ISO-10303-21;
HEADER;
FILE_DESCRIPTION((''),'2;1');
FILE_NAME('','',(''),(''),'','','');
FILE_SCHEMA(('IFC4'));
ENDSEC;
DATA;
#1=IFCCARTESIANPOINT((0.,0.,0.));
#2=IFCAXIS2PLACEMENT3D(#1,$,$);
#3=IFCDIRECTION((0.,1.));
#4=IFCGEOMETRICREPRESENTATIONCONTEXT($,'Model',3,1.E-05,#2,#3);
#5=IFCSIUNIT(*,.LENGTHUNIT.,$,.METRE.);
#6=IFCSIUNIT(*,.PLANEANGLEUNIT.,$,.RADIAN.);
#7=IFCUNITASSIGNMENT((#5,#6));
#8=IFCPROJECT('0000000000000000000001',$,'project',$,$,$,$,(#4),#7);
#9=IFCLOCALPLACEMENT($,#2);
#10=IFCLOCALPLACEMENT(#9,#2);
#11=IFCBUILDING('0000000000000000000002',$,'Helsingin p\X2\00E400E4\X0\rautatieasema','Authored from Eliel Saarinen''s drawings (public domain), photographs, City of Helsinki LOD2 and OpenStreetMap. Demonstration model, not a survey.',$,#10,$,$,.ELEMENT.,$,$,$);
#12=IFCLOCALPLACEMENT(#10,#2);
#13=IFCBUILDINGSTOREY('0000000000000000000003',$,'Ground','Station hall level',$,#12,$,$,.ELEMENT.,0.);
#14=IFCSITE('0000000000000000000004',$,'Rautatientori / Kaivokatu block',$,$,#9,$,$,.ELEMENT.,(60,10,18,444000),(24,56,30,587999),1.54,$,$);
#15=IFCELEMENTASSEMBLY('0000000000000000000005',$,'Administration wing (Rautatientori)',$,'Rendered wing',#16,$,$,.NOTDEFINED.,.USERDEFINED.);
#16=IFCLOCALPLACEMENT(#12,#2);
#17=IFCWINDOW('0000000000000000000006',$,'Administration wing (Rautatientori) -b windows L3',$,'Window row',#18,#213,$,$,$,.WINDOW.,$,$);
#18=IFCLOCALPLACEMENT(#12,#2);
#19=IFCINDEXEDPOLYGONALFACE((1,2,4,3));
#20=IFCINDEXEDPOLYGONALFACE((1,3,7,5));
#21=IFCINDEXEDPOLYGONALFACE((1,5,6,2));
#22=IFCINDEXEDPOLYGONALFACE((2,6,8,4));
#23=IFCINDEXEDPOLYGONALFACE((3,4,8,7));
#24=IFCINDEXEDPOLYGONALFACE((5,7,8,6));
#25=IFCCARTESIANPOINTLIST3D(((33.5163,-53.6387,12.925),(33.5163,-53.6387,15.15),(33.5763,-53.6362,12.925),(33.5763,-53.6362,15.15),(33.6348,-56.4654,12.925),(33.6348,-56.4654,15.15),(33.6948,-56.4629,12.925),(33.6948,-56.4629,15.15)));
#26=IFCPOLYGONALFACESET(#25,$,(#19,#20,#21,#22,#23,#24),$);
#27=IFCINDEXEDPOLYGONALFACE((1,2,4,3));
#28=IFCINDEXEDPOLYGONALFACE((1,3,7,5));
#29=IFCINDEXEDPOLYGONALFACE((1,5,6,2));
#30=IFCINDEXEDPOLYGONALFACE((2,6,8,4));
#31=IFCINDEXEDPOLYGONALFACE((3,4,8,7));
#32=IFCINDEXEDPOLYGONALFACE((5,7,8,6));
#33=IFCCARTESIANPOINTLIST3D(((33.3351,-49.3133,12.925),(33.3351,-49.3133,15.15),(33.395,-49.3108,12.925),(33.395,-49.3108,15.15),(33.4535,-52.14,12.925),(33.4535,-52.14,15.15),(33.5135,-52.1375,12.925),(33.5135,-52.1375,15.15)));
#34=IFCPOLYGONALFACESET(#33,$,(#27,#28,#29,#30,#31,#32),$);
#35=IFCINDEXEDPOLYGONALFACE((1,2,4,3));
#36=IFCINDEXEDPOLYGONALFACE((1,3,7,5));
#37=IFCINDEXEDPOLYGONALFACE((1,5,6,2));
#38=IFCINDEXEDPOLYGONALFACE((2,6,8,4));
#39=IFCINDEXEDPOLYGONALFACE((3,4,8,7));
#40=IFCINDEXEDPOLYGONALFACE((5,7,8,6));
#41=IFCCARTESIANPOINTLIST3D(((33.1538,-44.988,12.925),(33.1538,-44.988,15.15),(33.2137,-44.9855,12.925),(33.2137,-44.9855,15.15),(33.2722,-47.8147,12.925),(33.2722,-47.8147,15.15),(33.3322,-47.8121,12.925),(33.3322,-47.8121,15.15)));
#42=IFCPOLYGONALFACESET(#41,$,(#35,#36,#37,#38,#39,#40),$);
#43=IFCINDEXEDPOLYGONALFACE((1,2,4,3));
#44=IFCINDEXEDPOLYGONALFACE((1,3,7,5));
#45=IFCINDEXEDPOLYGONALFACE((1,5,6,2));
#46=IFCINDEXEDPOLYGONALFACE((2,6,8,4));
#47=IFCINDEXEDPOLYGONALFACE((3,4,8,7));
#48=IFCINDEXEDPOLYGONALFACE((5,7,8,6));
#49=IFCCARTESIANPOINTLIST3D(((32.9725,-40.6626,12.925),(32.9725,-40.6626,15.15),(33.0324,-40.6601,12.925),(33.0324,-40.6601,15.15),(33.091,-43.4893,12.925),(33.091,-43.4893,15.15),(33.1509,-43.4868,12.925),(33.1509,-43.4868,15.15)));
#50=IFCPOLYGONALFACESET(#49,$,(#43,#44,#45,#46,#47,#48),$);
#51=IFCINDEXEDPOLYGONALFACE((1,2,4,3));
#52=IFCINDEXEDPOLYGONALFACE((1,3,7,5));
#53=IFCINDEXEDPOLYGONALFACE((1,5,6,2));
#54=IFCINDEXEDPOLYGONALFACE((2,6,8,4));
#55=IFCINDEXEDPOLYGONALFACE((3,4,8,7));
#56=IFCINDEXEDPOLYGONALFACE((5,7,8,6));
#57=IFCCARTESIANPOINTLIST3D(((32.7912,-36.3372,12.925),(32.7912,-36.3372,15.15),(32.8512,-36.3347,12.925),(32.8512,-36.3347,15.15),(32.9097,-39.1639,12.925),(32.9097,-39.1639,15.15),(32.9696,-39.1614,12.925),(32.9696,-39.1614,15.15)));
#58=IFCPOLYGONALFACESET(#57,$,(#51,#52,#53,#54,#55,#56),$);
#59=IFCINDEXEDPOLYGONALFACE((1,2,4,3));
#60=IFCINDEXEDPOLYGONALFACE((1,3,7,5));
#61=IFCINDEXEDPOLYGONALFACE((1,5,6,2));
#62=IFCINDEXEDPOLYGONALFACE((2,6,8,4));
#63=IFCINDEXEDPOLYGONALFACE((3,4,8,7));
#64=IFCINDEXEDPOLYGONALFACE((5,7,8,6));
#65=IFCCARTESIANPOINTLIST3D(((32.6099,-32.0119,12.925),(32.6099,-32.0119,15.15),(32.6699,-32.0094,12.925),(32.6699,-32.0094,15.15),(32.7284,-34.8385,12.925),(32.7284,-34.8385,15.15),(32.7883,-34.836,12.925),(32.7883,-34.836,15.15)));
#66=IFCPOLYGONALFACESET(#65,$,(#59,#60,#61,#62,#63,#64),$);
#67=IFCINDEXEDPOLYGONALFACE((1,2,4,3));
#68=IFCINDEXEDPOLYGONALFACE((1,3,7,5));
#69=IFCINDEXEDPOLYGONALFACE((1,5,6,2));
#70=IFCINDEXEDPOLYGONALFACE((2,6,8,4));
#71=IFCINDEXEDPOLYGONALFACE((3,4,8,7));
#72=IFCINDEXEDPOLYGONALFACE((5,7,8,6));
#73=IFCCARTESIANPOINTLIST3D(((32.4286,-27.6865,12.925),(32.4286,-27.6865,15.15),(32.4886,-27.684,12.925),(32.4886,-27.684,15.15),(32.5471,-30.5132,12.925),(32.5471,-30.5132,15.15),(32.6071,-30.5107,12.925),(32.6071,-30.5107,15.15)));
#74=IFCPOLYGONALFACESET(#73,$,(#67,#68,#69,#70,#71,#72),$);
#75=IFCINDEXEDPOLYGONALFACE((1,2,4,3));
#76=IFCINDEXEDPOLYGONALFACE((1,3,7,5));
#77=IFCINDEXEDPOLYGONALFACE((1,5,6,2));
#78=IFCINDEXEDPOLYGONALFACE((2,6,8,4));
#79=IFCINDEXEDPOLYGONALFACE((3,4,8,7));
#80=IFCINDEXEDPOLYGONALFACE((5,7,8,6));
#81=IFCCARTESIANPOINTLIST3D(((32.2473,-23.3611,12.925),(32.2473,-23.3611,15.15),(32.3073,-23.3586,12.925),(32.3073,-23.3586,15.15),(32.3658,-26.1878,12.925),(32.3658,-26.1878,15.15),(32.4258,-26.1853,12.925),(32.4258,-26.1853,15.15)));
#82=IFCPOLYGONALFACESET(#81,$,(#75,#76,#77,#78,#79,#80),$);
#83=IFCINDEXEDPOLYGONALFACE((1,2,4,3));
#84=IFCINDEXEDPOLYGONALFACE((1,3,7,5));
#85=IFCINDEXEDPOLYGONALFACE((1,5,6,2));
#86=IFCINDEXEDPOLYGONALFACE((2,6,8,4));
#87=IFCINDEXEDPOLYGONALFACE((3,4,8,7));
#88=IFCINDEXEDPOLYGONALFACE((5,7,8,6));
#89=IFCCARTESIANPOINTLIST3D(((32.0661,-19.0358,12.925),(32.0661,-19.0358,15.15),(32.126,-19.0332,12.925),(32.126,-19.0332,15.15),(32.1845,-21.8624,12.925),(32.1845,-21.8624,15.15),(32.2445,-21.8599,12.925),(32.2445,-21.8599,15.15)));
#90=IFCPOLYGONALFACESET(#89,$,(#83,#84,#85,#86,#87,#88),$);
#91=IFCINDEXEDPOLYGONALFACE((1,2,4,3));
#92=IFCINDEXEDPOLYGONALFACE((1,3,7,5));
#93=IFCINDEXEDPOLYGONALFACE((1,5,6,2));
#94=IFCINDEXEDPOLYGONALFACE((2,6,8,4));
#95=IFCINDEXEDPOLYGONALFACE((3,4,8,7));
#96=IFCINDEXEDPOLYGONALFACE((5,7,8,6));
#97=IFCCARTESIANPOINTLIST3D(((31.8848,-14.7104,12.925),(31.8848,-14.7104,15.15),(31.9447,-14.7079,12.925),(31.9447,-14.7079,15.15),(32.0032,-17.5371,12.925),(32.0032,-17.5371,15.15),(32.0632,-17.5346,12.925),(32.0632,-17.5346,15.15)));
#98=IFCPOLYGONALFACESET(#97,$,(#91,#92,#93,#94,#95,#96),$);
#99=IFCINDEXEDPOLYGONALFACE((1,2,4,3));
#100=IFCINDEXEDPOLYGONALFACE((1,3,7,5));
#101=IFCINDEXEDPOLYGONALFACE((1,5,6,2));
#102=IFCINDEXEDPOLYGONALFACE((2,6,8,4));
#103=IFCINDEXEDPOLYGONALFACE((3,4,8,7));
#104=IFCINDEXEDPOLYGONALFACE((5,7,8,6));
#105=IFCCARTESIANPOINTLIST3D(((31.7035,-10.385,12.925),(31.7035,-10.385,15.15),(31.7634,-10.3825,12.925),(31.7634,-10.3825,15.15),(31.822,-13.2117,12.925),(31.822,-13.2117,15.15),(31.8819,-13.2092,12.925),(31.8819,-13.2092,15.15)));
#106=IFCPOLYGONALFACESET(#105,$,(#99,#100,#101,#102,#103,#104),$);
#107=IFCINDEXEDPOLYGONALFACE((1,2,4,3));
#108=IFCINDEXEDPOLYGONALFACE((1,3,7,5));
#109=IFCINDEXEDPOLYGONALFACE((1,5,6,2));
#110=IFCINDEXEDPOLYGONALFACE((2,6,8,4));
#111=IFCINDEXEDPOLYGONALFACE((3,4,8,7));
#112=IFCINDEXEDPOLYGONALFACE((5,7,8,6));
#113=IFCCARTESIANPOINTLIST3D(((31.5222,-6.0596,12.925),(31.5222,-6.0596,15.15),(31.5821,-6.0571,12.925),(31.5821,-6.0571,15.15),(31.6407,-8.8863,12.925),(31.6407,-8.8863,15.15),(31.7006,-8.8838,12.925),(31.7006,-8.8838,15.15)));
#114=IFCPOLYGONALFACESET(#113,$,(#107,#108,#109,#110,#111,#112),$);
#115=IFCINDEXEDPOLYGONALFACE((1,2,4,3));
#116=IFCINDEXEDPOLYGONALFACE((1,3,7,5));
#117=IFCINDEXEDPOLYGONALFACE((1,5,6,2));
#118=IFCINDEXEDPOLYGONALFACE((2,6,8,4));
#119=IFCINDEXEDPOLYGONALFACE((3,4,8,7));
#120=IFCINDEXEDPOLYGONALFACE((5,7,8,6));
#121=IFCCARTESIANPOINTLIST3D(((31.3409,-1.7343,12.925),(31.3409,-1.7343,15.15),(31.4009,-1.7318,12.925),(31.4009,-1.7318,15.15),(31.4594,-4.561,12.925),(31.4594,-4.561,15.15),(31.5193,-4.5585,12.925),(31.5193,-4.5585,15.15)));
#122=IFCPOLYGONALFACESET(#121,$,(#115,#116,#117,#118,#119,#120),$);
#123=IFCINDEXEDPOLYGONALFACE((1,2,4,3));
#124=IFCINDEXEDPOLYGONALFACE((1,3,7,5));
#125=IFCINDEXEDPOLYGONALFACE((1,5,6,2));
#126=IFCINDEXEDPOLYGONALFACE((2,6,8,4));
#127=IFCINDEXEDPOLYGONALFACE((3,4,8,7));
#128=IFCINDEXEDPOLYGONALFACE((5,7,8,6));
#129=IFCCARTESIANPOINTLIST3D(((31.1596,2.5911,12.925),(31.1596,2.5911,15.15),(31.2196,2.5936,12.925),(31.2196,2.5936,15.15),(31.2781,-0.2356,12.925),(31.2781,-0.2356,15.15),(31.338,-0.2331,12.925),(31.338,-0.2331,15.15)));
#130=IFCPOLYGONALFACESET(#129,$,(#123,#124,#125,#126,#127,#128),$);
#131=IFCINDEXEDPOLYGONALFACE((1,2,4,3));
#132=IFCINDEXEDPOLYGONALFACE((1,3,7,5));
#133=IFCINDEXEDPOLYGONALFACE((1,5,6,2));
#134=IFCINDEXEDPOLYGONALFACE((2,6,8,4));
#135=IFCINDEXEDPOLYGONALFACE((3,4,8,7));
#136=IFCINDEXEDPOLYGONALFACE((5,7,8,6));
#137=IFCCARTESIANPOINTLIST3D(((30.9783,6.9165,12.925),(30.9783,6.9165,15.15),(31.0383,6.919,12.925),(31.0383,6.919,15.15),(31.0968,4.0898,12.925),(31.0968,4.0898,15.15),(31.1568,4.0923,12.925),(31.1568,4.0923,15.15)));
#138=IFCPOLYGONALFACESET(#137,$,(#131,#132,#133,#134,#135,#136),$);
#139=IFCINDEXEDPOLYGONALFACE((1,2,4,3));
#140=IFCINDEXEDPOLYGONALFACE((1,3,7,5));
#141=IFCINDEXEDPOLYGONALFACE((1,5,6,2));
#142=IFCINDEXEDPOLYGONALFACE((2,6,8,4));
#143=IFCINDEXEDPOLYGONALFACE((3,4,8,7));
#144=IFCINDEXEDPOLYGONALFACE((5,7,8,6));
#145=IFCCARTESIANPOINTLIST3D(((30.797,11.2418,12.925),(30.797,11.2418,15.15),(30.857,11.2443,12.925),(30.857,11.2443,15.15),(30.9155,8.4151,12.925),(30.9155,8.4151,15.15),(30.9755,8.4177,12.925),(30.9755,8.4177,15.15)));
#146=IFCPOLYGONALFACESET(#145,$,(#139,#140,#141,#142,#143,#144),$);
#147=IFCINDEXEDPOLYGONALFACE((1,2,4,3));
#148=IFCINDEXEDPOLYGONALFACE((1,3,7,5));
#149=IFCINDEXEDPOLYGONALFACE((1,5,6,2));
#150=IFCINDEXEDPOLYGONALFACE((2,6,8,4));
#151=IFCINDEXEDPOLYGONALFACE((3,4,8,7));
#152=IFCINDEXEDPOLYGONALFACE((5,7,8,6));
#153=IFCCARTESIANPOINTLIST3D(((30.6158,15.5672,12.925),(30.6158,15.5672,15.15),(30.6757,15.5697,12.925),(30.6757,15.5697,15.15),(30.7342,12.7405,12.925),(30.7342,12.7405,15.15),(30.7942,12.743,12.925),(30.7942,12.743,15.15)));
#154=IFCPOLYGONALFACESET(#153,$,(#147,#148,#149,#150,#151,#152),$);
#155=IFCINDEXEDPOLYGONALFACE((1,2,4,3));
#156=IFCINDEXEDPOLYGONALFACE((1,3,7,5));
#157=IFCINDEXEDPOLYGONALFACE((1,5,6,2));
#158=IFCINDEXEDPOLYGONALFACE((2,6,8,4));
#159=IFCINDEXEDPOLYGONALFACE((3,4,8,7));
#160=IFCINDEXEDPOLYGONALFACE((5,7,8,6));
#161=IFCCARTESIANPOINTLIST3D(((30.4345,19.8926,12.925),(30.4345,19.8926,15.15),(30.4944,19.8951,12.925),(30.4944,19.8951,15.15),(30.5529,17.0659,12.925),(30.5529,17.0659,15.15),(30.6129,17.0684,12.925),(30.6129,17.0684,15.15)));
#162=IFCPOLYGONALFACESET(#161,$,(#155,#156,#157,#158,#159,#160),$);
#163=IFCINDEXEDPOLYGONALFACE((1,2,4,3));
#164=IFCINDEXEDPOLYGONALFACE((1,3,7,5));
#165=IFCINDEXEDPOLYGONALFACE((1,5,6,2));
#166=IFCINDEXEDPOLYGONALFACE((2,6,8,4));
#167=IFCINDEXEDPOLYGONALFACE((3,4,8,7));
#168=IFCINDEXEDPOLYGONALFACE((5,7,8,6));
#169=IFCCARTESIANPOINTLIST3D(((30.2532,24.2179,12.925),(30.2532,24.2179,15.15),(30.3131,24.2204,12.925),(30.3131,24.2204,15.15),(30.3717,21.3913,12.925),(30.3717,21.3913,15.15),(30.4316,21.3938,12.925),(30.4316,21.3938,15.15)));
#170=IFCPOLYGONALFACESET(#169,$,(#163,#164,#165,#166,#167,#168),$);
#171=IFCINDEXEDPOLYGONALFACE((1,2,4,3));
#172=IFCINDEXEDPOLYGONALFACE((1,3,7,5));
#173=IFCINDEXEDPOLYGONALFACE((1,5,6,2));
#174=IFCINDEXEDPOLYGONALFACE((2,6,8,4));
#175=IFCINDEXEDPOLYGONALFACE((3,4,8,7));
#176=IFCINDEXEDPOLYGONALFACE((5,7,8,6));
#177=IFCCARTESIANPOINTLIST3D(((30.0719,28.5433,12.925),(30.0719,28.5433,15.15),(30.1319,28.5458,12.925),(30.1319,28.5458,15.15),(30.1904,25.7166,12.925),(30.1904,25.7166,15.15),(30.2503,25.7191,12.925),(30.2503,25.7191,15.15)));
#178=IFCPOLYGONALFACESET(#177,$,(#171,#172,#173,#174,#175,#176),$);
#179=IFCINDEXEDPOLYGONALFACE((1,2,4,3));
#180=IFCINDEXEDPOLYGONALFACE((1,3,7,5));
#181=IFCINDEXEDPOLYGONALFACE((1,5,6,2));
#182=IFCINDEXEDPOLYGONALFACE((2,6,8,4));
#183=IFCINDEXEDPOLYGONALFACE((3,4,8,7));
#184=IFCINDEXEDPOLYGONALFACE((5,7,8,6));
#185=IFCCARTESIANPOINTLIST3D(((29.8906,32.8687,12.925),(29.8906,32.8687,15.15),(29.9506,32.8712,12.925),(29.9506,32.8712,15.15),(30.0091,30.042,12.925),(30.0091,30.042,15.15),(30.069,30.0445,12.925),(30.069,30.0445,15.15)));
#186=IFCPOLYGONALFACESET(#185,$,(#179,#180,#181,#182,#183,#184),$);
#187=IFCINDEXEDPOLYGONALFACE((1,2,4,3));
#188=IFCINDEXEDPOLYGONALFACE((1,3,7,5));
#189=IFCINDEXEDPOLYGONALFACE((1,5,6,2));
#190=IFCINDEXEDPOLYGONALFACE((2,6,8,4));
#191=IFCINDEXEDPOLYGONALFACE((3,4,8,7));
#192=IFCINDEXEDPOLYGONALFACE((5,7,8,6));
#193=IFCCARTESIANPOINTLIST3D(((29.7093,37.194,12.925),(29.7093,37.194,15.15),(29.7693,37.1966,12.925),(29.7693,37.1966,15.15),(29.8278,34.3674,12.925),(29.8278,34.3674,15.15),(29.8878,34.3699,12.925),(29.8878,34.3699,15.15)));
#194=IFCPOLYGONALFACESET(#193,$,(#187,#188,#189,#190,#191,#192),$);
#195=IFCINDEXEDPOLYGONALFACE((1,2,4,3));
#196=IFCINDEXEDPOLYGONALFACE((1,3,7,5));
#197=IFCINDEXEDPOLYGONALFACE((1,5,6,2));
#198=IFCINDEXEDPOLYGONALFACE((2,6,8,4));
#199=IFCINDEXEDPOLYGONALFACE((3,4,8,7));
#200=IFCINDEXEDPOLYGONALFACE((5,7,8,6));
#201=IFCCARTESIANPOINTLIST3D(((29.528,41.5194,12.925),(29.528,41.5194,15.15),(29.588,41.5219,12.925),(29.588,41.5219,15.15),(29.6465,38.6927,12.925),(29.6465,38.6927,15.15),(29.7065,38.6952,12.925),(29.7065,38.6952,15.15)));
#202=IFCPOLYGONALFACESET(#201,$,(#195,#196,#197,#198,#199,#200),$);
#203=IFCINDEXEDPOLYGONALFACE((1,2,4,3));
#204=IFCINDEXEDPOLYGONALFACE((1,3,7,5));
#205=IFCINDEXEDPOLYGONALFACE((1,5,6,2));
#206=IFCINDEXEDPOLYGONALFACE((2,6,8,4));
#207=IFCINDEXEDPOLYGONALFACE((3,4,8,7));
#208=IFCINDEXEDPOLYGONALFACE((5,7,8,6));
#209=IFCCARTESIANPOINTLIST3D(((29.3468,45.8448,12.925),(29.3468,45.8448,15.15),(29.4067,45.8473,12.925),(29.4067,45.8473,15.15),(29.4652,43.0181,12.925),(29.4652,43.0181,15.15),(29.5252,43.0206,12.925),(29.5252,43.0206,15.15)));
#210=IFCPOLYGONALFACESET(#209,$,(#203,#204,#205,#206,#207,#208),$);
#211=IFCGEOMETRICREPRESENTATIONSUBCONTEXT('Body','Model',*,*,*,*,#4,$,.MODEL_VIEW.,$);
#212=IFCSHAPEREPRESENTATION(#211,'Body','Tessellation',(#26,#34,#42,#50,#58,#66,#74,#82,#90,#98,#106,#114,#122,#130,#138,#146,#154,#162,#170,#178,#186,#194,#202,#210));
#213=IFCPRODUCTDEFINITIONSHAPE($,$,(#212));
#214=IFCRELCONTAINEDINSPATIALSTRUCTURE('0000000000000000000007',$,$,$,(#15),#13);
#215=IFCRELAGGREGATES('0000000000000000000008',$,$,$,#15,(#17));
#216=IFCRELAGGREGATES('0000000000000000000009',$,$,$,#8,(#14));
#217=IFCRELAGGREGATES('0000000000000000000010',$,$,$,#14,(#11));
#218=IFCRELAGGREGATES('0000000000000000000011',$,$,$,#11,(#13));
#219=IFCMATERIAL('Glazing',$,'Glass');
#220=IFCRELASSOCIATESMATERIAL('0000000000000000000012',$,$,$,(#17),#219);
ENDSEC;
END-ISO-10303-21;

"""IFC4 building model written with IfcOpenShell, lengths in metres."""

from ifc_helpers import new_model, si_unit, direction, frame, frame_2d, origin, place, context, subcontext, project, spatial, rectangle, extrude, material, element, aggregate, save


model = new_model("IFC4")

# Units and contexts
model_context = context("Model", 3, precision=1e-05, world=origin(), true_north=direction((0.0, 1.0)))
body_context = subcontext(model_context, "Body", "Model", "MODEL_VIEW")
ifc_project = project(units=[si_unit("LENGTHUNIT", "METRE"), si_unit("PLANEANGLEUNIT", "RADIAN")], contexts=[model_context])

# Site, building, storey
site_placement = place(None, origin())
site = spatial("IfcSite", under=ifc_project, at=site_placement, Name="Rautatientori / Kaivokatu block", CompositionType="ELEMENT", RefLatitude=(60, 10, 18, 444000), RefLongitude=(24, 56, 30, 587999), RefElevation=1.54)
building_placement = place(site_placement, origin())
building = spatial("IfcBuilding", under=site, at=building_placement, Name="Helsingin päärautatieasema", Description="Authored from Eliel Saarinen's drawings (public domain), photographs, City of Helsinki LOD2 and OpenStreetMap. Demonstration model, not a survey.", CompositionType="ELEMENT")
storey_placement = place(building_placement, origin())
storey = spatial("IfcBuildingStorey", under=building, at=storey_placement, Name="Ground", Description="Station hall level", CompositionType="ELEMENT", Elevation=0.0)

# Element assembly, window
assembly_placement = place(building_placement, origin())
assembly = element("IfcElementAssembly", 1, at=assembly_placement, inside=storey, Name="Administration wing (Rautatientori)", ObjectType="Rendered wing", AssemblyPlace="NOTDEFINED", PredefinedType="USERDEFINED")
ifc_material_1 = material(Name="Glazing", Category="Glass")
window_1_placement = place(building_placement, origin())
window_1 = element("IfcWindow", 2, at=window_1_placement, material=ifc_material_1, Name="Administration wing (Rautatientori) -b windows L3", ObjectType="Window row", PredefinedType="WINDOW", context=body_context, shape_type="SweptSolid", body=[
    extrude(rectangle(XDim=2.8292, YDim=0.06, at=frame_2d((0.0, 0.0), x_axis=(-0.041876, 0.999123))), frame((33.6056, -55.0508, 12.925)), (0.0, 0.0, 1.0), 2.225),
    extrude(rectangle(XDim=2.8292, YDim=0.06, at=frame_2d((0.0, 0.0), x_axis=(-0.041876, 0.999123))), frame((33.4243, -50.7254, 12.925)), (0.0, 0.0, 1.0), 2.225),
    extrude(rectangle(XDim=2.8292, YDim=0.06, at=frame_2d((0.0, 0.0), x_axis=(-0.041876, 0.999123))), frame((33.243, -46.4001, 12.925)), (0.0, 0.0, 1.0), 2.225),
    extrude(rectangle(XDim=2.8292, YDim=0.06, at=frame_2d((0.0, 0.0), x_axis=(-0.041876, 0.999123))), frame((33.0617, -42.0747, 12.925)), (0.0, 0.0, 1.0), 2.225),
    extrude(rectangle(XDim=2.8292, YDim=0.06, at=frame_2d((0.0, 0.0), x_axis=(-0.041876, 0.999123))), frame((32.8804, -37.7493, 12.925)), (0.0, 0.0, 1.0), 2.225),
    extrude(rectangle(XDim=2.8292, YDim=0.06, at=frame_2d((0.0, 0.0), x_axis=(-0.041876, 0.999123))), frame((32.6991, -33.4239, 12.925)), (0.0, 0.0, 1.0), 2.225),
    extrude(rectangle(XDim=2.8292, YDim=0.06, at=frame_2d((0.0, 0.0), x_axis=(-0.041876, 0.999123))), frame((32.5178, -29.0986, 12.925)), (0.0, 0.0, 1.0), 2.225),
    extrude(rectangle(XDim=2.8292, YDim=0.06, at=frame_2d((0.0, 0.0), x_axis=(-0.041876, 0.999123))), frame((32.3366, -24.7732, 12.925)), (0.0, 0.0, 1.0), 2.225),
    extrude(rectangle(XDim=2.8292, YDim=0.06, at=frame_2d((0.0, 0.0), x_axis=(-0.041876, 0.999123))), frame((32.1553, -20.4478, 12.925)), (0.0, 0.0, 1.0), 2.225),
    extrude(rectangle(XDim=2.8292, YDim=0.06, at=frame_2d((0.0, 0.0), x_axis=(-0.041876, 0.999123))), frame((31.974, -16.1225, 12.925)), (0.0, 0.0, 1.0), 2.225),
    extrude(rectangle(XDim=2.8292, YDim=0.06, at=frame_2d((0.0, 0.0), x_axis=(-0.041876, 0.999123))), frame((31.7927, -11.7971, 12.925)), (0.0, 0.0, 1.0), 2.225),
    extrude(rectangle(XDim=2.8292, YDim=0.06, at=frame_2d((0.0, 0.0), x_axis=(-0.041876, 0.999123))), frame((31.6114, -7.4717, 12.925)), (0.0, 0.0, 1.0), 2.225),
    extrude(rectangle(XDim=2.8292, YDim=0.06, at=frame_2d((0.0, 0.0), x_axis=(-0.041876, 0.999123))), frame((31.4301, -3.1464, 12.925)), (0.0, 0.0, 1.0), 2.225),
    extrude(rectangle(XDim=2.8292, YDim=0.06, at=frame_2d((0.0, 0.0), x_axis=(-0.041876, 0.999123))), frame((31.2488, 1.179, 12.925)), (0.0, 0.0, 1.0), 2.225),
    extrude(rectangle(XDim=2.8292, YDim=0.06, at=frame_2d((0.0, 0.0), x_axis=(-0.041876, 0.999123))), frame((31.0675, 5.5044, 12.925)), (0.0, 0.0, 1.0), 2.225),
    extrude(rectangle(XDim=2.8292, YDim=0.06, at=frame_2d((0.0, 0.0), x_axis=(-0.041876, 0.999123))), frame((30.8863, 9.8297, 12.925)), (0.0, 0.0, 1.0), 2.225),
    extrude(rectangle(XDim=2.8292, YDim=0.06, at=frame_2d((0.0, 0.0), x_axis=(-0.041876, 0.999123))), frame((30.705, 14.1551, 12.925)), (0.0, 0.0, 1.0), 2.225),
    extrude(rectangle(XDim=2.8292, YDim=0.06, at=frame_2d((0.0, 0.0), x_axis=(-0.041876, 0.999123))), frame((30.5237, 18.4805, 12.925)), (0.0, 0.0, 1.0), 2.225),
    extrude(rectangle(XDim=2.8292, YDim=0.06, at=frame_2d((0.0, 0.0), x_axis=(-0.041876, 0.999123))), frame((30.3424, 22.8059, 12.925)), (0.0, 0.0, 1.0), 2.225),
    extrude(rectangle(XDim=2.8292, YDim=0.06, at=frame_2d((0.0, 0.0), x_axis=(-0.041876, 0.999123))), frame((30.1611, 27.1312, 12.925)), (0.0, 0.0, 1.0), 2.225),
    extrude(rectangle(XDim=2.8292, YDim=0.06, at=frame_2d((0.0, 0.0), x_axis=(-0.041876, 0.999123))), frame((29.9798, 31.4566, 12.925)), (0.0, 0.0, 1.0), 2.225),
    extrude(rectangle(XDim=2.8292, YDim=0.06, at=frame_2d((0.0, 0.0), x_axis=(-0.041876, 0.999123))), frame((29.7985, 35.782, 12.925)), (0.0, 0.0, 1.0), 2.225),
    extrude(rectangle(XDim=2.8292, YDim=0.06, at=frame_2d((0.0, 0.0), x_axis=(-0.041876, 0.999123))), frame((29.6173, 40.1073, 12.925)), (0.0, 0.0, 1.0), 2.225),
    extrude(rectangle(XDim=2.8292, YDim=0.06, at=frame_2d((0.0, 0.0), x_axis=(-0.041876, 0.999123))), frame((29.436, 44.4327, 12.925)), (0.0, 0.0, 1.0), 2.225),
])
aggregate(assembly, [window_1])

save(model, "model.ifc")
